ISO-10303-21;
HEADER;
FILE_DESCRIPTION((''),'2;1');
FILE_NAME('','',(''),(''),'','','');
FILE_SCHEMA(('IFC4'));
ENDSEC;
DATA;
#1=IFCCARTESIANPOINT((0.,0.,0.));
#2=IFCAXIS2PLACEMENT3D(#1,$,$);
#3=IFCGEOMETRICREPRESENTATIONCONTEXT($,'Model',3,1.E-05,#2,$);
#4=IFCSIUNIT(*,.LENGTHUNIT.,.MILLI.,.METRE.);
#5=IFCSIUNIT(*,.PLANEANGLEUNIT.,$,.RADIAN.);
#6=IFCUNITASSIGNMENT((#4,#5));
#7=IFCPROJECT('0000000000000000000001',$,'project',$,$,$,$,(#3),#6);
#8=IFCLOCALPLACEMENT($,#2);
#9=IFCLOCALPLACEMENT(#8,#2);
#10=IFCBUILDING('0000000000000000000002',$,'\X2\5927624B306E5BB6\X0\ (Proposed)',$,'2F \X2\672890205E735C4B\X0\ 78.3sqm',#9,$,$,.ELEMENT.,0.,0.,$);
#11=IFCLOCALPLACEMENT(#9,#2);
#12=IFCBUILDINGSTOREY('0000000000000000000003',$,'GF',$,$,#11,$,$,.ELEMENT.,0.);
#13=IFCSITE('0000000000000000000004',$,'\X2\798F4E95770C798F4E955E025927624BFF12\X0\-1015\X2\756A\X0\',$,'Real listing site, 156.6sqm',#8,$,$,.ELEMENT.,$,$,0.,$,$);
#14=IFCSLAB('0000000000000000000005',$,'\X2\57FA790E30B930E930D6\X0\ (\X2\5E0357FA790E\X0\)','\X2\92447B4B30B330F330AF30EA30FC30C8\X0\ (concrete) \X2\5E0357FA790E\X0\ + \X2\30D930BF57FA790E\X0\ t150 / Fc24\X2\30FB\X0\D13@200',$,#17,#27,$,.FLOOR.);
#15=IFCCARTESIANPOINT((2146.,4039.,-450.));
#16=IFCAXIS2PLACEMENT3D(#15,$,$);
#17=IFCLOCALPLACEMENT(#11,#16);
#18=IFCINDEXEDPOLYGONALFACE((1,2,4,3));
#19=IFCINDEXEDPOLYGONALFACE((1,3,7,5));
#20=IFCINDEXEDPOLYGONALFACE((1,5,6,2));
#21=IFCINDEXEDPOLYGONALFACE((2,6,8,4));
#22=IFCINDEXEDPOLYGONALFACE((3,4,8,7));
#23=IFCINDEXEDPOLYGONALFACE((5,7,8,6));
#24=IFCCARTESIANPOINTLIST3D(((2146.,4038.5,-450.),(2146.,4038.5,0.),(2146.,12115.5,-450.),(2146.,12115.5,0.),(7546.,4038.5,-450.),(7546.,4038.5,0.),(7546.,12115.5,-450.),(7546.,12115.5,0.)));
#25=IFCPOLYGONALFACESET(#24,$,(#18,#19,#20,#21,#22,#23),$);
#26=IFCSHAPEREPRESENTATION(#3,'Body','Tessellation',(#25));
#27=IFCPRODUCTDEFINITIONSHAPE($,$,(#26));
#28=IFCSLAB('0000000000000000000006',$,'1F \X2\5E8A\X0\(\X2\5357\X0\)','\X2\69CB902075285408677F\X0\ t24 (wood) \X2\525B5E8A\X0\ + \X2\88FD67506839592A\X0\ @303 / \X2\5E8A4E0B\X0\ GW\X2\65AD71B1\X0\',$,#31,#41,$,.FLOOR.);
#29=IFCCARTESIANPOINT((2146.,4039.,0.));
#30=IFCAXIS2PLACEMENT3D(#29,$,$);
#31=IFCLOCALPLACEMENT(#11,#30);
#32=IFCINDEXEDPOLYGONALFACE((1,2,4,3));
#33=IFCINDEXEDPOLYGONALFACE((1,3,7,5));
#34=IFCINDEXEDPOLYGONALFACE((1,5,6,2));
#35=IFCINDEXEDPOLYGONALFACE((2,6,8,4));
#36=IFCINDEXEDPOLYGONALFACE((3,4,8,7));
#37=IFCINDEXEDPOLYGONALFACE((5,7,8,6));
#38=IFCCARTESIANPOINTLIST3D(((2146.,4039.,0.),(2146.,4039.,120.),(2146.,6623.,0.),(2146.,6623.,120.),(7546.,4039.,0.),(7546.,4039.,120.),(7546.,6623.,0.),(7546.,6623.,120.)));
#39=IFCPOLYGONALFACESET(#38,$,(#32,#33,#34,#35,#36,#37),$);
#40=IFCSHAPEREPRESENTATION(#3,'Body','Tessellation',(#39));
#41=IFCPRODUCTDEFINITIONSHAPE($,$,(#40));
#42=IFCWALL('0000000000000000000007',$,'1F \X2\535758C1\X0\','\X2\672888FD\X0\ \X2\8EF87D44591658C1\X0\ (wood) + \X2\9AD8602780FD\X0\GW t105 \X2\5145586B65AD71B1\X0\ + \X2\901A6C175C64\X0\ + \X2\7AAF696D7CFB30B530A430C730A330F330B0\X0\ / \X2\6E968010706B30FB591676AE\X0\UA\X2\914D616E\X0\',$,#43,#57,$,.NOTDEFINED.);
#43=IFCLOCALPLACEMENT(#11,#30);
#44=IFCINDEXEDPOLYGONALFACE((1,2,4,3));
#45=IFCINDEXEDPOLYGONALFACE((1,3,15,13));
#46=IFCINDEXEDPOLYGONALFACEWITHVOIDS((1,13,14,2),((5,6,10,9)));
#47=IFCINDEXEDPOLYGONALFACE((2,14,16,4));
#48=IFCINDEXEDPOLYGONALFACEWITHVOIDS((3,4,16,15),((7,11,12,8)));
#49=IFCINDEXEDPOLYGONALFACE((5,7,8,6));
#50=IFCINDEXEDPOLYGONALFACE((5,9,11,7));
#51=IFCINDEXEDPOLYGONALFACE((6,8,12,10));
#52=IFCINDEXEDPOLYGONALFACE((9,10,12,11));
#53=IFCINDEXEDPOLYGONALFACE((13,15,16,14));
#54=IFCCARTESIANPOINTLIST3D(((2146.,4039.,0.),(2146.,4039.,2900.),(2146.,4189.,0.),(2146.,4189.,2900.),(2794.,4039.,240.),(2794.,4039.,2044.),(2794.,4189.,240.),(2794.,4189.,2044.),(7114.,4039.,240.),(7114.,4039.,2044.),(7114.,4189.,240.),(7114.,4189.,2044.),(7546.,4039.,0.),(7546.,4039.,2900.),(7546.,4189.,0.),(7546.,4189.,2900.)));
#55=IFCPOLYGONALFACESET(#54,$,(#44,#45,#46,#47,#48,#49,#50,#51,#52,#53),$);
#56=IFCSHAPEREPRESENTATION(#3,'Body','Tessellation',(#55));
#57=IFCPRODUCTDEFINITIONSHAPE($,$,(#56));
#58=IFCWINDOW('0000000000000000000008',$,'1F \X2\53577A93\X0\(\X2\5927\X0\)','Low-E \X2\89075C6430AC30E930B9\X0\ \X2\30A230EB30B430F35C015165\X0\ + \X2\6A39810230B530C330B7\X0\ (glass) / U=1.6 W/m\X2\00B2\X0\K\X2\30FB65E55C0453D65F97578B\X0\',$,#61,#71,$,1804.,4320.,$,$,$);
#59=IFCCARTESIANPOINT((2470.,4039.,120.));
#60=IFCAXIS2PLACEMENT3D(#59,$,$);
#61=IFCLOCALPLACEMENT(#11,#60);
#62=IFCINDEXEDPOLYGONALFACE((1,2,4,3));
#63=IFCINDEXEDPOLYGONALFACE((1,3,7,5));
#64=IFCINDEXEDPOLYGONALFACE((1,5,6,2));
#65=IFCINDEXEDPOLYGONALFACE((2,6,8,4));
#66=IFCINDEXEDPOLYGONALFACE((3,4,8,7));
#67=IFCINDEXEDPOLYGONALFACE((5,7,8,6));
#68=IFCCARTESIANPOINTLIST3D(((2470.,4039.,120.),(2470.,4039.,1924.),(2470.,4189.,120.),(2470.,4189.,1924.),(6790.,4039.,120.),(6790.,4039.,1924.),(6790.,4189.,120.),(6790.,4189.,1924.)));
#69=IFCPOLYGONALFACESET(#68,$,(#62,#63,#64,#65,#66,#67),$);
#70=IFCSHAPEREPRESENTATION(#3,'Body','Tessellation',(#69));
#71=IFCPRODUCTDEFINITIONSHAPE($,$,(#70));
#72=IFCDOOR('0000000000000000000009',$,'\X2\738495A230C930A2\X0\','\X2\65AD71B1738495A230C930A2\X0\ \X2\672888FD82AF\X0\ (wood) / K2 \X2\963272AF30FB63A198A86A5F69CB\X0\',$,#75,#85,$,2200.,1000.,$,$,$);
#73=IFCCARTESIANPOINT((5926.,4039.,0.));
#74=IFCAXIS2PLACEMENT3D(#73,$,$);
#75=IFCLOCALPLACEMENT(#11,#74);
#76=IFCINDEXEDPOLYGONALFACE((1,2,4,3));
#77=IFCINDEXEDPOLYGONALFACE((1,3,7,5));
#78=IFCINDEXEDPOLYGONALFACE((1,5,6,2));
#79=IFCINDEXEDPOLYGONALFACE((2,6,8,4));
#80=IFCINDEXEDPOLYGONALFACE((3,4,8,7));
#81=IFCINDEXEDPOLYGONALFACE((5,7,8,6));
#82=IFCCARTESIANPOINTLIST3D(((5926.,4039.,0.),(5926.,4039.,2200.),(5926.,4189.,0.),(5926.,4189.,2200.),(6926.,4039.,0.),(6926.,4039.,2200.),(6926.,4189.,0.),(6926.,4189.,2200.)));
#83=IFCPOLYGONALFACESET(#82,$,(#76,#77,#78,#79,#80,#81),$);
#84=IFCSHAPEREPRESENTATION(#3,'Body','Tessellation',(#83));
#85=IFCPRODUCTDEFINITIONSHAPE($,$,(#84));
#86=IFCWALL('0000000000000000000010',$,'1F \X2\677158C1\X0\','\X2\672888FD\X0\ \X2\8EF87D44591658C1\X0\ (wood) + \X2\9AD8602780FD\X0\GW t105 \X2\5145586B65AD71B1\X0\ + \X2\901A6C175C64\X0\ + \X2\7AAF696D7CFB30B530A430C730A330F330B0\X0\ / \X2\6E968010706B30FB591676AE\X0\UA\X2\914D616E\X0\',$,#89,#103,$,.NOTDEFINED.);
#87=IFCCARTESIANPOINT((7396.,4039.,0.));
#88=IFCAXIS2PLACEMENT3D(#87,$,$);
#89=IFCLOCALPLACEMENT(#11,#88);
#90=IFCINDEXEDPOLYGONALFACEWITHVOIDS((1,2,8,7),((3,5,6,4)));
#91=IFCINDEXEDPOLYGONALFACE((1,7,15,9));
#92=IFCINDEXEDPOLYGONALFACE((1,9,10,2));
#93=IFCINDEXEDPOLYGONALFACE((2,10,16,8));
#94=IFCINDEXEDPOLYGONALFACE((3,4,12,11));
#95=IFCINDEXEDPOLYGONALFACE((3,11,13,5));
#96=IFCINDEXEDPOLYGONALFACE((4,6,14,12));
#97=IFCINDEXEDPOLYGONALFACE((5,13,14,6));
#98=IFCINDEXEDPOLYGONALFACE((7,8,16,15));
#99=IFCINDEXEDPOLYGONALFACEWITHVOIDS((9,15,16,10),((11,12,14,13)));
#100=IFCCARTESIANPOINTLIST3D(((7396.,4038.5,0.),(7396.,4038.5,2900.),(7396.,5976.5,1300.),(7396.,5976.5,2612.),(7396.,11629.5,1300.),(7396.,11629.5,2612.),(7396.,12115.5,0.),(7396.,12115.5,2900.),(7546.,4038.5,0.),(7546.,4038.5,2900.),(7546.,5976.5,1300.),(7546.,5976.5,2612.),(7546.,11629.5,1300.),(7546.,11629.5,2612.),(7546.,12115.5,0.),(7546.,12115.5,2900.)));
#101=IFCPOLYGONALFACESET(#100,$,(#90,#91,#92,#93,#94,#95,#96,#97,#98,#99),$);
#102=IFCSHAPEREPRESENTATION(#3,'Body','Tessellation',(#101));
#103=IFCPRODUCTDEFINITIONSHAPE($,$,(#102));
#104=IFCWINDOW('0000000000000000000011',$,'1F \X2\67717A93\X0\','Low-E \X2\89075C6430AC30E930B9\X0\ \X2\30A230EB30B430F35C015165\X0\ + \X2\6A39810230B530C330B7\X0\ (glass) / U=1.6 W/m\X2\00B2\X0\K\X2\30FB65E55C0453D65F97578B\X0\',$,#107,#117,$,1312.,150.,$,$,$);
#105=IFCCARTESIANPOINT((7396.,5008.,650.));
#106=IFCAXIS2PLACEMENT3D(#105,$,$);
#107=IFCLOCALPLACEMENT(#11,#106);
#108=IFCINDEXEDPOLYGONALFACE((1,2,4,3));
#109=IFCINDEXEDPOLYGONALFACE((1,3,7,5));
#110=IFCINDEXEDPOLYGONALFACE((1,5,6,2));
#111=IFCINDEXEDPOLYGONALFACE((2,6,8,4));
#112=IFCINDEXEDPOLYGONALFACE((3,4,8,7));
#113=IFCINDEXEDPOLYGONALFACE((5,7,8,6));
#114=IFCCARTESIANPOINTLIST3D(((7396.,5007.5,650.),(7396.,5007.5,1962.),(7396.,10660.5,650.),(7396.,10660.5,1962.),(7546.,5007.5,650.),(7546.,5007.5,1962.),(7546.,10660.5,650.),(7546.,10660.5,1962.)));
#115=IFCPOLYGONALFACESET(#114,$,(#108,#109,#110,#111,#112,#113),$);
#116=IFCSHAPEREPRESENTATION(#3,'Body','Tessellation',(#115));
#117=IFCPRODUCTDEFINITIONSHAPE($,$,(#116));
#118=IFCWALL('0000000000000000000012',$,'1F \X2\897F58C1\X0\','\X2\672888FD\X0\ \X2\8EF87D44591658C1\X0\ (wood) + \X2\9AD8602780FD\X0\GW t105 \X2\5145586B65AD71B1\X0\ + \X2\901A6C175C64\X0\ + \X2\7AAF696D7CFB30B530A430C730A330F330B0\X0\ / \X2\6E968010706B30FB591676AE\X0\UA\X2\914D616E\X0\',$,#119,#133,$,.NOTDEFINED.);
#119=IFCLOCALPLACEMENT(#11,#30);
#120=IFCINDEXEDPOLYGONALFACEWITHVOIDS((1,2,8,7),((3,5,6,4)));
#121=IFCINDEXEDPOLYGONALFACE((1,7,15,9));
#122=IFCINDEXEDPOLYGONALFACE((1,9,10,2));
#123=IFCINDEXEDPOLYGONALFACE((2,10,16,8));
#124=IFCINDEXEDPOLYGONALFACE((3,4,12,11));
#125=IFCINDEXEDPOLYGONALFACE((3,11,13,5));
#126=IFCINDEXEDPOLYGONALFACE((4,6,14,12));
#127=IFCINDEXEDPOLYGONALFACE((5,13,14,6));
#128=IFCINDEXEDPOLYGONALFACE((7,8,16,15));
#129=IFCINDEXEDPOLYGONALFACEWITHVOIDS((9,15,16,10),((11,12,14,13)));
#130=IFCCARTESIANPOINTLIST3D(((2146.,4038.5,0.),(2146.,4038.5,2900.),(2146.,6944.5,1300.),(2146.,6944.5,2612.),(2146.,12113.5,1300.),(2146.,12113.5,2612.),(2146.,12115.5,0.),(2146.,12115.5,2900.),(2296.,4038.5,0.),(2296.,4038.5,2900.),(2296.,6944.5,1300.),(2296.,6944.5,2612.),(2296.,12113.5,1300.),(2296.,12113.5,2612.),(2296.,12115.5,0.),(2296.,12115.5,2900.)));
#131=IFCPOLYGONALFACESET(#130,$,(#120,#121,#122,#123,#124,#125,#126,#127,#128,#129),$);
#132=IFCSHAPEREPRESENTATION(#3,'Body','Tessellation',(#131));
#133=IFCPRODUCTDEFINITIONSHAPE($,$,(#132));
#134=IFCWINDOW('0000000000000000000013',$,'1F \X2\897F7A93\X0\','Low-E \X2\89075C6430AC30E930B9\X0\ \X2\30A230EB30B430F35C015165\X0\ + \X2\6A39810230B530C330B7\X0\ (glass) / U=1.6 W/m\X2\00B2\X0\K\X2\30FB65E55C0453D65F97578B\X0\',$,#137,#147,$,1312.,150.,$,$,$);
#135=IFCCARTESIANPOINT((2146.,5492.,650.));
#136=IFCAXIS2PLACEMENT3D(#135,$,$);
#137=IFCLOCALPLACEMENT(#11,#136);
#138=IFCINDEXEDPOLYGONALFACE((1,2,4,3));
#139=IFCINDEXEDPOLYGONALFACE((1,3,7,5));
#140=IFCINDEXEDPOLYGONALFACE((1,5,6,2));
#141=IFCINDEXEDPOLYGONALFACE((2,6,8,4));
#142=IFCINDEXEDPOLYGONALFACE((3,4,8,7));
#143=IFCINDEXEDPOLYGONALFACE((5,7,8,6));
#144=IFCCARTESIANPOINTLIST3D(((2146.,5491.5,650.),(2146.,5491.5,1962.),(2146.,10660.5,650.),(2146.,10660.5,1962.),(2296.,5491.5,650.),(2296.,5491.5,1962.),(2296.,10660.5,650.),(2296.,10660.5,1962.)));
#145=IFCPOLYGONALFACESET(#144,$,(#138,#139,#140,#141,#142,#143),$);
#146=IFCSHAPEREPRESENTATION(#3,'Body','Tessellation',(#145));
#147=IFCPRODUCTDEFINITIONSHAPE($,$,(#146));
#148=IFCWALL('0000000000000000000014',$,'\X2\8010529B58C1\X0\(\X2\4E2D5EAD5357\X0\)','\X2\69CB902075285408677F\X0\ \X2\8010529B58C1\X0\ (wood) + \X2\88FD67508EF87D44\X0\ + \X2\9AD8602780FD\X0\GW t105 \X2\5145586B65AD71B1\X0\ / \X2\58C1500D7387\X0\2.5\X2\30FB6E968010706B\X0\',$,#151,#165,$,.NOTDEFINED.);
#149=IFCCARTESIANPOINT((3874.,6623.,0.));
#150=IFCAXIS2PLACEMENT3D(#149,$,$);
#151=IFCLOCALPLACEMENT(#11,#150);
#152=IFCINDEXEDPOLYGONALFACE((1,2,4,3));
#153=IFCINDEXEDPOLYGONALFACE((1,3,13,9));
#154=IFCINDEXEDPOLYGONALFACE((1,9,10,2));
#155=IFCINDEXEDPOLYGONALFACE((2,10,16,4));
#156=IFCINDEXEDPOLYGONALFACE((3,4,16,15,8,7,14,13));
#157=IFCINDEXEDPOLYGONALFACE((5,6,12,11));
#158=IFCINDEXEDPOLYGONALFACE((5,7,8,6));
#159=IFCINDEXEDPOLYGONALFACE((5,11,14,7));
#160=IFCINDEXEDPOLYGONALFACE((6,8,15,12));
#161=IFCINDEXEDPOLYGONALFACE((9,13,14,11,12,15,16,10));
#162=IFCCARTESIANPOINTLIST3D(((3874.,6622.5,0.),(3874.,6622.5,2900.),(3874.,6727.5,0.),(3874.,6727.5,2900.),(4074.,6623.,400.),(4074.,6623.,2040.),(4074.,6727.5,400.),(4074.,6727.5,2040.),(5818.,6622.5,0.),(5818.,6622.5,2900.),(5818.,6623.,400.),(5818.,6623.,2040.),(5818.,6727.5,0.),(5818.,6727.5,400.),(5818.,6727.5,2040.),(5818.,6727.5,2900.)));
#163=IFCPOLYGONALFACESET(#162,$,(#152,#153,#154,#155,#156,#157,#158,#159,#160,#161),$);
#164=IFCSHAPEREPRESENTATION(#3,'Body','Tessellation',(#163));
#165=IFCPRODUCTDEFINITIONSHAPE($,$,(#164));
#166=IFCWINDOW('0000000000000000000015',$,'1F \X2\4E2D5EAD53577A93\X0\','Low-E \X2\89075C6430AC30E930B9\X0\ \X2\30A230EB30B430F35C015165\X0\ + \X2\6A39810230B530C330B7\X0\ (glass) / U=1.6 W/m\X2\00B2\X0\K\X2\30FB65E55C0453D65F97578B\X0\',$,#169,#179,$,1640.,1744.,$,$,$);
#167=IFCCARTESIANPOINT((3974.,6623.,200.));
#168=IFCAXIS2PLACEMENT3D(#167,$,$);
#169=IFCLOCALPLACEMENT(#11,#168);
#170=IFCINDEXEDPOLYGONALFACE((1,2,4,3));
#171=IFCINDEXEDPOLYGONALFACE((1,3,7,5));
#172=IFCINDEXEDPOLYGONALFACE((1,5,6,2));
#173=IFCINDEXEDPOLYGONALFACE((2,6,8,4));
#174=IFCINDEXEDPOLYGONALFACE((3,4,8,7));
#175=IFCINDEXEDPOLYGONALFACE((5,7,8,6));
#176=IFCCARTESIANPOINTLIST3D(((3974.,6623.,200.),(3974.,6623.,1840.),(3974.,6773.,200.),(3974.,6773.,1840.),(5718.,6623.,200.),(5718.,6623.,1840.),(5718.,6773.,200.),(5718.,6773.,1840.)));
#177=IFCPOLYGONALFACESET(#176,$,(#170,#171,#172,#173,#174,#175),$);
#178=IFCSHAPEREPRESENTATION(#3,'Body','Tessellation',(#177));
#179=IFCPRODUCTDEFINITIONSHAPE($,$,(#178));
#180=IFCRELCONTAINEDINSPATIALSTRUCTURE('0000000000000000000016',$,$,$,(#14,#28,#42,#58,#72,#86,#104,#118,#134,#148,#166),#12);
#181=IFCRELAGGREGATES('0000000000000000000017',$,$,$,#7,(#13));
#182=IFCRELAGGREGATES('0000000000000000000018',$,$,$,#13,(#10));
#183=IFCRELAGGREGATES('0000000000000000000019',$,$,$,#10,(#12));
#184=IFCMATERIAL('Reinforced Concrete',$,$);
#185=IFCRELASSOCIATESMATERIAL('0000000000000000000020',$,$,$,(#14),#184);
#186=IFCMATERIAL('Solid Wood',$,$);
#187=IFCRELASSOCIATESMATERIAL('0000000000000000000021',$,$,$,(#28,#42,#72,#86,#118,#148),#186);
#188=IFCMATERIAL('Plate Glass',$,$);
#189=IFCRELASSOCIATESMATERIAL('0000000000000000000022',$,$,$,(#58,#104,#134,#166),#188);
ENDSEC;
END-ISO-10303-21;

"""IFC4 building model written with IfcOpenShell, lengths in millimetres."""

from ifc_helpers import new_model, si_unit, frame, frame_2d, origin, place, context, project, spatial, rectangle, extrude, material, element, fill, save


model = new_model("IFC4")

# Units and contexts
model_context = context("Model", 3, precision=1e-05, world=origin())
ifc_project = project(units=[si_unit("LENGTHUNIT", "METRE", prefix="MILLI"), si_unit("PLANEANGLEUNIT", "RADIAN")], contexts=[model_context])

# Site, building, storey
site_placement = place(None, origin())
site = spatial("IfcSite", under=ifc_project, at=site_placement, Name="福井県福井市大手２-1015番", ObjectType="Real listing site, 156.6sqm", CompositionType="ELEMENT", RefElevation=0.0)
building_placement = place(site_placement, origin())
building = spatial("IfcBuilding", under=site, at=building_placement, Name="大手の家 (Proposed)", ObjectType="2F 木造平屋 78.3sqm", CompositionType="ELEMENT", ElevationOfRefHeight=0.0, ElevationOfTerrain=0.0)
storey_placement = place(building_placement, origin())
storey = spatial("IfcBuildingStorey", under=building, at=storey_placement, Name="GF", CompositionType="ELEMENT", Elevation=0.0)

# Slabs
ifc_material_1 = material(Name="Reinforced Concrete")
slab_1_placement = place(storey_placement, frame((2146.0, 4039.0, -450.0)))
element("IfcSlab", 1, at=slab_1_placement, inside=storey, material=ifc_material_1, Name="基礎スラブ (布基礎)", Description="鉄筋コンクリート (concrete) 布基礎 + ベタ基礎 t150 / Fc24・D13@200", PredefinedType="FLOOR", context=model_context, shape_type="SweptSolid", body=[
    extrude(rectangle(XDim=5400.0, YDim=8077.0, at=frame_2d((2700.0, 4038.0))), frame((2146.0, 4039.0, -450.0)), (0.0, 0.0, 1.0), 450.0),
])
ifc_material_2 = material(Name="Solid Wood")
slab_2_placement = place(storey_placement, frame((2146.0, 4039.0, 0.0)))
element("IfcSlab", 2, at=slab_2_placement, inside=storey, material=ifc_material_2, Name="1F 床(南)", Description="構造用合板 t24 (wood) 剛床 + 製材根太 @303 / 床下 GW断熱", PredefinedType="FLOOR", context=model_context, shape_type="SweptSolid", body=[
    extrude(rectangle(XDim=5400.0, YDim=2584.0, at=frame_2d((2700.0, 1292.0))), frame((2146.0, 4039.0, 0.0)), (0.0, 0.0, 1.0), 120.0),
])

# Wall, openings, window, door
wall_1_placement = place(storey_placement, frame((2146.0, 4039.0, 0.0)))
wall_1 = element("IfcWall", 3, at=wall_1_placement, inside=storey, material=ifc_material_2, Name="1F 南壁", Description="木製 軸組外壁 (wood) + 高性能GW t105 充填断熱 + 通気層 + 窯業系サイディング / 準耐火・外皮UA配慮", PredefinedType="NOTDEFINED", context=model_context, shape_type="SweptSolid", body=[
    extrude(rectangle(XDim=5400.0, YDim=150.0, at=frame_2d((2700.0, 75.0))), frame((2146.0, 4039.0, 0.0)), (0.0, 0.0, 1.0), 2900.0),
])
opening_1_placement = place(storey_placement, frame((2470.0, 4039.0, 120.0)))
opening_1 = element("IfcOpeningElement", 4, at=opening_1_placement, cuts=wall_1, PredefinedType="NOTDEFINED", context=model_context, shape_type="SweptSolid", body=[
    extrude(rectangle(XDim=4320.0, YDim=150.0, at=frame_2d((2160.0, 75.0))), frame((2470.0, 4039.0, 120.0)), (0.0, 0.0, 1.0), 1804.0),
])
opening_2_placement = place(storey_placement, frame((5926.0, 4039.0, 0.0)))
opening_2 = element("IfcOpeningElement", 5, at=opening_2_placement, cuts=wall_1, PredefinedType="NOTDEFINED", context=model_context, shape_type="SweptSolid", body=[
    extrude(rectangle(XDim=1000.0, YDim=150.0, at=frame_2d((500.0, 75.0))), frame((5926.0, 4039.0, 0.0)), (0.0, 0.0, 1.0), 2200.0),
])
ifc_material_3 = material(Name="Plate Glass")
window_1_placement = place(storey_placement, frame((2470.0, 4039.0, 120.0)))
window_1 = element("IfcWindow", 6, at=window_1_placement, inside=storey, material=ifc_material_3, Name="1F 南窓(大)", Description="Low-E 複層ガラス アルゴン封入 + 樹脂サッシ (glass) / U=1.6 W/m²K・日射取得型", OverallHeight=1804.0, OverallWidth=4320.0, context=model_context, shape_type="SweptSolid", body=[
    extrude(rectangle(XDim=4320.0, YDim=150.0, at=frame_2d((2160.0, 75.0))), frame((2470.0, 4039.0, 120.0)), (0.0, 0.0, 1.0), 1804.0),
])
fill(opening_1, window_1)
door_placement = place(storey_placement, frame((5926.0, 4039.0, 0.0)))
door = element("IfcDoor", 7, at=door_placement, inside=storey, material=ifc_material_2, Name="玄関ドア", Description="断熱玄関ドア 木製芯 (wood) / K2 防犯・採風機構", OverallHeight=2200.0, OverallWidth=1000.0, context=model_context, shape_type="SweptSolid", body=[
    extrude(rectangle(XDim=1000.0, YDim=150.0, at=frame_2d((500.0, 75.0))), frame((5926.0, 4039.0, 0.0)), (0.0, 0.0, 1.0), 2200.0),
])
fill(opening_2, door)

# Walls, openings, windows
wall_2_placement = place(storey_placement, frame((7396.0, 4039.0, 0.0)))
wall_2 = element("IfcWall", 8, at=wall_2_placement, inside=storey, material=ifc_material_2, Name="1F 東壁", Description="木製 軸組外壁 (wood) + 高性能GW t105 充填断熱 + 通気層 + 窯業系サイディング / 準耐火・外皮UA配慮", PredefinedType="NOTDEFINED", context=model_context, shape_type="SweptSolid", body=[
    extrude(rectangle(XDim=150.0, YDim=8077.0, at=frame_2d((75.0, 4038.0))), frame((7396.0, 4039.0, 0.0)), (0.0, 0.0, 1.0), 2900.0),
])
opening_3_placement = place(storey_placement, frame((7396.0, 5008.0, 650.0)))
opening_3 = element("IfcOpeningElement", 9, at=opening_3_placement, cuts=wall_2, PredefinedType="NOTDEFINED", context=model_context, shape_type="SweptSolid", body=[
    extrude(rectangle(XDim=150.0, YDim=5653.0, at=frame_2d((75.0, 2826.0))), frame((7396.0, 5008.0, 650.0)), (0.0, 0.0, 1.0), 1312.0),
])
window_2_placement = place(storey_placement, frame((7396.0, 5008.0, 650.0)))
window_2 = element("IfcWindow", 10, at=window_2_placement, inside=storey, material=ifc_material_3, Name="1F 東窓", Description="Low-E 複層ガラス アルゴン封入 + 樹脂サッシ (glass) / U=1.6 W/m²K・日射取得型", OverallHeight=1312.0, OverallWidth=150.0, context=model_context, shape_type="SweptSolid", body=[
    extrude(rectangle(XDim=150.0, YDim=5653.0, at=frame_2d((75.0, 2826.0))), frame((7396.0, 5008.0, 650.0)), (0.0, 0.0, 1.0), 1312.0),
])
fill(opening_3, window_2)
wall_3_placement = place(storey_placement, frame((2146.0, 4039.0, 0.0)))
wall_3 = element("IfcWall", 11, at=wall_3_placement, inside=storey, material=ifc_material_2, Name="1F 西壁", Description="木製 軸組外壁 (wood) + 高性能GW t105 充填断熱 + 通気層 + 窯業系サイディング / 準耐火・外皮UA配慮", PredefinedType="NOTDEFINED", context=model_context, shape_type="SweptSolid", body=[
    extrude(rectangle(XDim=150.0, YDim=8077.0, at=frame_2d((75.0, 4038.0))), frame((2146.0, 4039.0, 0.0)), (0.0, 0.0, 1.0), 2900.0),
])
opening_4_placement = place(storey_placement, frame((2146.0, 5492.0, 650.0)))
opening_4 = element("IfcOpeningElement", 12, at=opening_4_placement, cuts=wall_3, PredefinedType="NOTDEFINED", context=model_context, shape_type="SweptSolid", body=[
    extrude(rectangle(XDim=150.0, YDim=5169.0, at=frame_2d((75.0, 2584.0))), frame((2146.0, 5492.0, 650.0)), (0.0, 0.0, 1.0), 1312.0),
])
window_3_placement = place(storey_placement, frame((2146.0, 5492.0, 650.0)))
window_3 = element("IfcWindow", 13, at=window_3_placement, inside=storey, material=ifc_material_3, Name="1F 西窓", Description="Low-E 複層ガラス アルゴン封入 + 樹脂サッシ (glass) / U=1.6 W/m²K・日射取得型", OverallHeight=1312.0, OverallWidth=150.0, context=model_context, shape_type="SweptSolid", body=[
    extrude(rectangle(XDim=150.0, YDim=5169.0, at=frame_2d((75.0, 2584.0))), frame((2146.0, 5492.0, 650.0)), (0.0, 0.0, 1.0), 1312.0),
])
fill(opening_4, window_3)
wall_4_placement = place(storey_placement, frame((3874.0, 6623.0, 0.0)))
wall_4 = element("IfcWall", 14, at=wall_4_placement, inside=storey, material=ifc_material_2, Name="耐力壁(中庭南)", Description="構造用合板 耐力壁 (wood) + 製材軸組 + 高性能GW t105 充填断熱 / 壁倍率2.5・準耐火", PredefinedType="NOTDEFINED", context=model_context, shape_type="SweptSolid", body=[
    extrude(rectangle(XDim=1944.0, YDim=105.0, at=frame_2d((972.0, 52.0))), frame((3874.0, 6623.0, 0.0)), (0.0, 0.0, 1.0), 2900.0),
])
opening_5_placement = place(storey_placement, frame((3974.0, 6623.0, 200.0)))
opening_5 = element("IfcOpeningElement", 15, at=opening_5_placement, cuts=wall_4, PredefinedType="NOTDEFINED", context=model_context, shape_type="SweptSolid", body=[
    extrude(rectangle(XDim=1744.0, YDim=150.0, at=frame_2d((872.0, 75.0))), frame((3974.0, 6623.0, 200.0)), (0.0, 0.0, 1.0), 1640.0),
])
window_4_placement = place(storey_placement, frame((3974.0, 6623.0, 200.0)))
window_4 = element("IfcWindow", 16, at=window_4_placement, inside=storey, material=ifc_material_3, Name="1F 中庭南窓", Description="Low-E 複層ガラス アルゴン封入 + 樹脂サッシ (glass) / U=1.6 W/m²K・日射取得型", OverallHeight=1640.0, OverallWidth=1744.0, context=model_context, shape_type="SweptSolid", body=[
    extrude(rectangle(XDim=1744.0, YDim=150.0, at=frame_2d((872.0, 75.0))), frame((3974.0, 6623.0, 200.0)), (0.0, 0.0, 1.0), 1640.0),
])
fill(opening_5, window_4)

save(model, "model.ifc")
